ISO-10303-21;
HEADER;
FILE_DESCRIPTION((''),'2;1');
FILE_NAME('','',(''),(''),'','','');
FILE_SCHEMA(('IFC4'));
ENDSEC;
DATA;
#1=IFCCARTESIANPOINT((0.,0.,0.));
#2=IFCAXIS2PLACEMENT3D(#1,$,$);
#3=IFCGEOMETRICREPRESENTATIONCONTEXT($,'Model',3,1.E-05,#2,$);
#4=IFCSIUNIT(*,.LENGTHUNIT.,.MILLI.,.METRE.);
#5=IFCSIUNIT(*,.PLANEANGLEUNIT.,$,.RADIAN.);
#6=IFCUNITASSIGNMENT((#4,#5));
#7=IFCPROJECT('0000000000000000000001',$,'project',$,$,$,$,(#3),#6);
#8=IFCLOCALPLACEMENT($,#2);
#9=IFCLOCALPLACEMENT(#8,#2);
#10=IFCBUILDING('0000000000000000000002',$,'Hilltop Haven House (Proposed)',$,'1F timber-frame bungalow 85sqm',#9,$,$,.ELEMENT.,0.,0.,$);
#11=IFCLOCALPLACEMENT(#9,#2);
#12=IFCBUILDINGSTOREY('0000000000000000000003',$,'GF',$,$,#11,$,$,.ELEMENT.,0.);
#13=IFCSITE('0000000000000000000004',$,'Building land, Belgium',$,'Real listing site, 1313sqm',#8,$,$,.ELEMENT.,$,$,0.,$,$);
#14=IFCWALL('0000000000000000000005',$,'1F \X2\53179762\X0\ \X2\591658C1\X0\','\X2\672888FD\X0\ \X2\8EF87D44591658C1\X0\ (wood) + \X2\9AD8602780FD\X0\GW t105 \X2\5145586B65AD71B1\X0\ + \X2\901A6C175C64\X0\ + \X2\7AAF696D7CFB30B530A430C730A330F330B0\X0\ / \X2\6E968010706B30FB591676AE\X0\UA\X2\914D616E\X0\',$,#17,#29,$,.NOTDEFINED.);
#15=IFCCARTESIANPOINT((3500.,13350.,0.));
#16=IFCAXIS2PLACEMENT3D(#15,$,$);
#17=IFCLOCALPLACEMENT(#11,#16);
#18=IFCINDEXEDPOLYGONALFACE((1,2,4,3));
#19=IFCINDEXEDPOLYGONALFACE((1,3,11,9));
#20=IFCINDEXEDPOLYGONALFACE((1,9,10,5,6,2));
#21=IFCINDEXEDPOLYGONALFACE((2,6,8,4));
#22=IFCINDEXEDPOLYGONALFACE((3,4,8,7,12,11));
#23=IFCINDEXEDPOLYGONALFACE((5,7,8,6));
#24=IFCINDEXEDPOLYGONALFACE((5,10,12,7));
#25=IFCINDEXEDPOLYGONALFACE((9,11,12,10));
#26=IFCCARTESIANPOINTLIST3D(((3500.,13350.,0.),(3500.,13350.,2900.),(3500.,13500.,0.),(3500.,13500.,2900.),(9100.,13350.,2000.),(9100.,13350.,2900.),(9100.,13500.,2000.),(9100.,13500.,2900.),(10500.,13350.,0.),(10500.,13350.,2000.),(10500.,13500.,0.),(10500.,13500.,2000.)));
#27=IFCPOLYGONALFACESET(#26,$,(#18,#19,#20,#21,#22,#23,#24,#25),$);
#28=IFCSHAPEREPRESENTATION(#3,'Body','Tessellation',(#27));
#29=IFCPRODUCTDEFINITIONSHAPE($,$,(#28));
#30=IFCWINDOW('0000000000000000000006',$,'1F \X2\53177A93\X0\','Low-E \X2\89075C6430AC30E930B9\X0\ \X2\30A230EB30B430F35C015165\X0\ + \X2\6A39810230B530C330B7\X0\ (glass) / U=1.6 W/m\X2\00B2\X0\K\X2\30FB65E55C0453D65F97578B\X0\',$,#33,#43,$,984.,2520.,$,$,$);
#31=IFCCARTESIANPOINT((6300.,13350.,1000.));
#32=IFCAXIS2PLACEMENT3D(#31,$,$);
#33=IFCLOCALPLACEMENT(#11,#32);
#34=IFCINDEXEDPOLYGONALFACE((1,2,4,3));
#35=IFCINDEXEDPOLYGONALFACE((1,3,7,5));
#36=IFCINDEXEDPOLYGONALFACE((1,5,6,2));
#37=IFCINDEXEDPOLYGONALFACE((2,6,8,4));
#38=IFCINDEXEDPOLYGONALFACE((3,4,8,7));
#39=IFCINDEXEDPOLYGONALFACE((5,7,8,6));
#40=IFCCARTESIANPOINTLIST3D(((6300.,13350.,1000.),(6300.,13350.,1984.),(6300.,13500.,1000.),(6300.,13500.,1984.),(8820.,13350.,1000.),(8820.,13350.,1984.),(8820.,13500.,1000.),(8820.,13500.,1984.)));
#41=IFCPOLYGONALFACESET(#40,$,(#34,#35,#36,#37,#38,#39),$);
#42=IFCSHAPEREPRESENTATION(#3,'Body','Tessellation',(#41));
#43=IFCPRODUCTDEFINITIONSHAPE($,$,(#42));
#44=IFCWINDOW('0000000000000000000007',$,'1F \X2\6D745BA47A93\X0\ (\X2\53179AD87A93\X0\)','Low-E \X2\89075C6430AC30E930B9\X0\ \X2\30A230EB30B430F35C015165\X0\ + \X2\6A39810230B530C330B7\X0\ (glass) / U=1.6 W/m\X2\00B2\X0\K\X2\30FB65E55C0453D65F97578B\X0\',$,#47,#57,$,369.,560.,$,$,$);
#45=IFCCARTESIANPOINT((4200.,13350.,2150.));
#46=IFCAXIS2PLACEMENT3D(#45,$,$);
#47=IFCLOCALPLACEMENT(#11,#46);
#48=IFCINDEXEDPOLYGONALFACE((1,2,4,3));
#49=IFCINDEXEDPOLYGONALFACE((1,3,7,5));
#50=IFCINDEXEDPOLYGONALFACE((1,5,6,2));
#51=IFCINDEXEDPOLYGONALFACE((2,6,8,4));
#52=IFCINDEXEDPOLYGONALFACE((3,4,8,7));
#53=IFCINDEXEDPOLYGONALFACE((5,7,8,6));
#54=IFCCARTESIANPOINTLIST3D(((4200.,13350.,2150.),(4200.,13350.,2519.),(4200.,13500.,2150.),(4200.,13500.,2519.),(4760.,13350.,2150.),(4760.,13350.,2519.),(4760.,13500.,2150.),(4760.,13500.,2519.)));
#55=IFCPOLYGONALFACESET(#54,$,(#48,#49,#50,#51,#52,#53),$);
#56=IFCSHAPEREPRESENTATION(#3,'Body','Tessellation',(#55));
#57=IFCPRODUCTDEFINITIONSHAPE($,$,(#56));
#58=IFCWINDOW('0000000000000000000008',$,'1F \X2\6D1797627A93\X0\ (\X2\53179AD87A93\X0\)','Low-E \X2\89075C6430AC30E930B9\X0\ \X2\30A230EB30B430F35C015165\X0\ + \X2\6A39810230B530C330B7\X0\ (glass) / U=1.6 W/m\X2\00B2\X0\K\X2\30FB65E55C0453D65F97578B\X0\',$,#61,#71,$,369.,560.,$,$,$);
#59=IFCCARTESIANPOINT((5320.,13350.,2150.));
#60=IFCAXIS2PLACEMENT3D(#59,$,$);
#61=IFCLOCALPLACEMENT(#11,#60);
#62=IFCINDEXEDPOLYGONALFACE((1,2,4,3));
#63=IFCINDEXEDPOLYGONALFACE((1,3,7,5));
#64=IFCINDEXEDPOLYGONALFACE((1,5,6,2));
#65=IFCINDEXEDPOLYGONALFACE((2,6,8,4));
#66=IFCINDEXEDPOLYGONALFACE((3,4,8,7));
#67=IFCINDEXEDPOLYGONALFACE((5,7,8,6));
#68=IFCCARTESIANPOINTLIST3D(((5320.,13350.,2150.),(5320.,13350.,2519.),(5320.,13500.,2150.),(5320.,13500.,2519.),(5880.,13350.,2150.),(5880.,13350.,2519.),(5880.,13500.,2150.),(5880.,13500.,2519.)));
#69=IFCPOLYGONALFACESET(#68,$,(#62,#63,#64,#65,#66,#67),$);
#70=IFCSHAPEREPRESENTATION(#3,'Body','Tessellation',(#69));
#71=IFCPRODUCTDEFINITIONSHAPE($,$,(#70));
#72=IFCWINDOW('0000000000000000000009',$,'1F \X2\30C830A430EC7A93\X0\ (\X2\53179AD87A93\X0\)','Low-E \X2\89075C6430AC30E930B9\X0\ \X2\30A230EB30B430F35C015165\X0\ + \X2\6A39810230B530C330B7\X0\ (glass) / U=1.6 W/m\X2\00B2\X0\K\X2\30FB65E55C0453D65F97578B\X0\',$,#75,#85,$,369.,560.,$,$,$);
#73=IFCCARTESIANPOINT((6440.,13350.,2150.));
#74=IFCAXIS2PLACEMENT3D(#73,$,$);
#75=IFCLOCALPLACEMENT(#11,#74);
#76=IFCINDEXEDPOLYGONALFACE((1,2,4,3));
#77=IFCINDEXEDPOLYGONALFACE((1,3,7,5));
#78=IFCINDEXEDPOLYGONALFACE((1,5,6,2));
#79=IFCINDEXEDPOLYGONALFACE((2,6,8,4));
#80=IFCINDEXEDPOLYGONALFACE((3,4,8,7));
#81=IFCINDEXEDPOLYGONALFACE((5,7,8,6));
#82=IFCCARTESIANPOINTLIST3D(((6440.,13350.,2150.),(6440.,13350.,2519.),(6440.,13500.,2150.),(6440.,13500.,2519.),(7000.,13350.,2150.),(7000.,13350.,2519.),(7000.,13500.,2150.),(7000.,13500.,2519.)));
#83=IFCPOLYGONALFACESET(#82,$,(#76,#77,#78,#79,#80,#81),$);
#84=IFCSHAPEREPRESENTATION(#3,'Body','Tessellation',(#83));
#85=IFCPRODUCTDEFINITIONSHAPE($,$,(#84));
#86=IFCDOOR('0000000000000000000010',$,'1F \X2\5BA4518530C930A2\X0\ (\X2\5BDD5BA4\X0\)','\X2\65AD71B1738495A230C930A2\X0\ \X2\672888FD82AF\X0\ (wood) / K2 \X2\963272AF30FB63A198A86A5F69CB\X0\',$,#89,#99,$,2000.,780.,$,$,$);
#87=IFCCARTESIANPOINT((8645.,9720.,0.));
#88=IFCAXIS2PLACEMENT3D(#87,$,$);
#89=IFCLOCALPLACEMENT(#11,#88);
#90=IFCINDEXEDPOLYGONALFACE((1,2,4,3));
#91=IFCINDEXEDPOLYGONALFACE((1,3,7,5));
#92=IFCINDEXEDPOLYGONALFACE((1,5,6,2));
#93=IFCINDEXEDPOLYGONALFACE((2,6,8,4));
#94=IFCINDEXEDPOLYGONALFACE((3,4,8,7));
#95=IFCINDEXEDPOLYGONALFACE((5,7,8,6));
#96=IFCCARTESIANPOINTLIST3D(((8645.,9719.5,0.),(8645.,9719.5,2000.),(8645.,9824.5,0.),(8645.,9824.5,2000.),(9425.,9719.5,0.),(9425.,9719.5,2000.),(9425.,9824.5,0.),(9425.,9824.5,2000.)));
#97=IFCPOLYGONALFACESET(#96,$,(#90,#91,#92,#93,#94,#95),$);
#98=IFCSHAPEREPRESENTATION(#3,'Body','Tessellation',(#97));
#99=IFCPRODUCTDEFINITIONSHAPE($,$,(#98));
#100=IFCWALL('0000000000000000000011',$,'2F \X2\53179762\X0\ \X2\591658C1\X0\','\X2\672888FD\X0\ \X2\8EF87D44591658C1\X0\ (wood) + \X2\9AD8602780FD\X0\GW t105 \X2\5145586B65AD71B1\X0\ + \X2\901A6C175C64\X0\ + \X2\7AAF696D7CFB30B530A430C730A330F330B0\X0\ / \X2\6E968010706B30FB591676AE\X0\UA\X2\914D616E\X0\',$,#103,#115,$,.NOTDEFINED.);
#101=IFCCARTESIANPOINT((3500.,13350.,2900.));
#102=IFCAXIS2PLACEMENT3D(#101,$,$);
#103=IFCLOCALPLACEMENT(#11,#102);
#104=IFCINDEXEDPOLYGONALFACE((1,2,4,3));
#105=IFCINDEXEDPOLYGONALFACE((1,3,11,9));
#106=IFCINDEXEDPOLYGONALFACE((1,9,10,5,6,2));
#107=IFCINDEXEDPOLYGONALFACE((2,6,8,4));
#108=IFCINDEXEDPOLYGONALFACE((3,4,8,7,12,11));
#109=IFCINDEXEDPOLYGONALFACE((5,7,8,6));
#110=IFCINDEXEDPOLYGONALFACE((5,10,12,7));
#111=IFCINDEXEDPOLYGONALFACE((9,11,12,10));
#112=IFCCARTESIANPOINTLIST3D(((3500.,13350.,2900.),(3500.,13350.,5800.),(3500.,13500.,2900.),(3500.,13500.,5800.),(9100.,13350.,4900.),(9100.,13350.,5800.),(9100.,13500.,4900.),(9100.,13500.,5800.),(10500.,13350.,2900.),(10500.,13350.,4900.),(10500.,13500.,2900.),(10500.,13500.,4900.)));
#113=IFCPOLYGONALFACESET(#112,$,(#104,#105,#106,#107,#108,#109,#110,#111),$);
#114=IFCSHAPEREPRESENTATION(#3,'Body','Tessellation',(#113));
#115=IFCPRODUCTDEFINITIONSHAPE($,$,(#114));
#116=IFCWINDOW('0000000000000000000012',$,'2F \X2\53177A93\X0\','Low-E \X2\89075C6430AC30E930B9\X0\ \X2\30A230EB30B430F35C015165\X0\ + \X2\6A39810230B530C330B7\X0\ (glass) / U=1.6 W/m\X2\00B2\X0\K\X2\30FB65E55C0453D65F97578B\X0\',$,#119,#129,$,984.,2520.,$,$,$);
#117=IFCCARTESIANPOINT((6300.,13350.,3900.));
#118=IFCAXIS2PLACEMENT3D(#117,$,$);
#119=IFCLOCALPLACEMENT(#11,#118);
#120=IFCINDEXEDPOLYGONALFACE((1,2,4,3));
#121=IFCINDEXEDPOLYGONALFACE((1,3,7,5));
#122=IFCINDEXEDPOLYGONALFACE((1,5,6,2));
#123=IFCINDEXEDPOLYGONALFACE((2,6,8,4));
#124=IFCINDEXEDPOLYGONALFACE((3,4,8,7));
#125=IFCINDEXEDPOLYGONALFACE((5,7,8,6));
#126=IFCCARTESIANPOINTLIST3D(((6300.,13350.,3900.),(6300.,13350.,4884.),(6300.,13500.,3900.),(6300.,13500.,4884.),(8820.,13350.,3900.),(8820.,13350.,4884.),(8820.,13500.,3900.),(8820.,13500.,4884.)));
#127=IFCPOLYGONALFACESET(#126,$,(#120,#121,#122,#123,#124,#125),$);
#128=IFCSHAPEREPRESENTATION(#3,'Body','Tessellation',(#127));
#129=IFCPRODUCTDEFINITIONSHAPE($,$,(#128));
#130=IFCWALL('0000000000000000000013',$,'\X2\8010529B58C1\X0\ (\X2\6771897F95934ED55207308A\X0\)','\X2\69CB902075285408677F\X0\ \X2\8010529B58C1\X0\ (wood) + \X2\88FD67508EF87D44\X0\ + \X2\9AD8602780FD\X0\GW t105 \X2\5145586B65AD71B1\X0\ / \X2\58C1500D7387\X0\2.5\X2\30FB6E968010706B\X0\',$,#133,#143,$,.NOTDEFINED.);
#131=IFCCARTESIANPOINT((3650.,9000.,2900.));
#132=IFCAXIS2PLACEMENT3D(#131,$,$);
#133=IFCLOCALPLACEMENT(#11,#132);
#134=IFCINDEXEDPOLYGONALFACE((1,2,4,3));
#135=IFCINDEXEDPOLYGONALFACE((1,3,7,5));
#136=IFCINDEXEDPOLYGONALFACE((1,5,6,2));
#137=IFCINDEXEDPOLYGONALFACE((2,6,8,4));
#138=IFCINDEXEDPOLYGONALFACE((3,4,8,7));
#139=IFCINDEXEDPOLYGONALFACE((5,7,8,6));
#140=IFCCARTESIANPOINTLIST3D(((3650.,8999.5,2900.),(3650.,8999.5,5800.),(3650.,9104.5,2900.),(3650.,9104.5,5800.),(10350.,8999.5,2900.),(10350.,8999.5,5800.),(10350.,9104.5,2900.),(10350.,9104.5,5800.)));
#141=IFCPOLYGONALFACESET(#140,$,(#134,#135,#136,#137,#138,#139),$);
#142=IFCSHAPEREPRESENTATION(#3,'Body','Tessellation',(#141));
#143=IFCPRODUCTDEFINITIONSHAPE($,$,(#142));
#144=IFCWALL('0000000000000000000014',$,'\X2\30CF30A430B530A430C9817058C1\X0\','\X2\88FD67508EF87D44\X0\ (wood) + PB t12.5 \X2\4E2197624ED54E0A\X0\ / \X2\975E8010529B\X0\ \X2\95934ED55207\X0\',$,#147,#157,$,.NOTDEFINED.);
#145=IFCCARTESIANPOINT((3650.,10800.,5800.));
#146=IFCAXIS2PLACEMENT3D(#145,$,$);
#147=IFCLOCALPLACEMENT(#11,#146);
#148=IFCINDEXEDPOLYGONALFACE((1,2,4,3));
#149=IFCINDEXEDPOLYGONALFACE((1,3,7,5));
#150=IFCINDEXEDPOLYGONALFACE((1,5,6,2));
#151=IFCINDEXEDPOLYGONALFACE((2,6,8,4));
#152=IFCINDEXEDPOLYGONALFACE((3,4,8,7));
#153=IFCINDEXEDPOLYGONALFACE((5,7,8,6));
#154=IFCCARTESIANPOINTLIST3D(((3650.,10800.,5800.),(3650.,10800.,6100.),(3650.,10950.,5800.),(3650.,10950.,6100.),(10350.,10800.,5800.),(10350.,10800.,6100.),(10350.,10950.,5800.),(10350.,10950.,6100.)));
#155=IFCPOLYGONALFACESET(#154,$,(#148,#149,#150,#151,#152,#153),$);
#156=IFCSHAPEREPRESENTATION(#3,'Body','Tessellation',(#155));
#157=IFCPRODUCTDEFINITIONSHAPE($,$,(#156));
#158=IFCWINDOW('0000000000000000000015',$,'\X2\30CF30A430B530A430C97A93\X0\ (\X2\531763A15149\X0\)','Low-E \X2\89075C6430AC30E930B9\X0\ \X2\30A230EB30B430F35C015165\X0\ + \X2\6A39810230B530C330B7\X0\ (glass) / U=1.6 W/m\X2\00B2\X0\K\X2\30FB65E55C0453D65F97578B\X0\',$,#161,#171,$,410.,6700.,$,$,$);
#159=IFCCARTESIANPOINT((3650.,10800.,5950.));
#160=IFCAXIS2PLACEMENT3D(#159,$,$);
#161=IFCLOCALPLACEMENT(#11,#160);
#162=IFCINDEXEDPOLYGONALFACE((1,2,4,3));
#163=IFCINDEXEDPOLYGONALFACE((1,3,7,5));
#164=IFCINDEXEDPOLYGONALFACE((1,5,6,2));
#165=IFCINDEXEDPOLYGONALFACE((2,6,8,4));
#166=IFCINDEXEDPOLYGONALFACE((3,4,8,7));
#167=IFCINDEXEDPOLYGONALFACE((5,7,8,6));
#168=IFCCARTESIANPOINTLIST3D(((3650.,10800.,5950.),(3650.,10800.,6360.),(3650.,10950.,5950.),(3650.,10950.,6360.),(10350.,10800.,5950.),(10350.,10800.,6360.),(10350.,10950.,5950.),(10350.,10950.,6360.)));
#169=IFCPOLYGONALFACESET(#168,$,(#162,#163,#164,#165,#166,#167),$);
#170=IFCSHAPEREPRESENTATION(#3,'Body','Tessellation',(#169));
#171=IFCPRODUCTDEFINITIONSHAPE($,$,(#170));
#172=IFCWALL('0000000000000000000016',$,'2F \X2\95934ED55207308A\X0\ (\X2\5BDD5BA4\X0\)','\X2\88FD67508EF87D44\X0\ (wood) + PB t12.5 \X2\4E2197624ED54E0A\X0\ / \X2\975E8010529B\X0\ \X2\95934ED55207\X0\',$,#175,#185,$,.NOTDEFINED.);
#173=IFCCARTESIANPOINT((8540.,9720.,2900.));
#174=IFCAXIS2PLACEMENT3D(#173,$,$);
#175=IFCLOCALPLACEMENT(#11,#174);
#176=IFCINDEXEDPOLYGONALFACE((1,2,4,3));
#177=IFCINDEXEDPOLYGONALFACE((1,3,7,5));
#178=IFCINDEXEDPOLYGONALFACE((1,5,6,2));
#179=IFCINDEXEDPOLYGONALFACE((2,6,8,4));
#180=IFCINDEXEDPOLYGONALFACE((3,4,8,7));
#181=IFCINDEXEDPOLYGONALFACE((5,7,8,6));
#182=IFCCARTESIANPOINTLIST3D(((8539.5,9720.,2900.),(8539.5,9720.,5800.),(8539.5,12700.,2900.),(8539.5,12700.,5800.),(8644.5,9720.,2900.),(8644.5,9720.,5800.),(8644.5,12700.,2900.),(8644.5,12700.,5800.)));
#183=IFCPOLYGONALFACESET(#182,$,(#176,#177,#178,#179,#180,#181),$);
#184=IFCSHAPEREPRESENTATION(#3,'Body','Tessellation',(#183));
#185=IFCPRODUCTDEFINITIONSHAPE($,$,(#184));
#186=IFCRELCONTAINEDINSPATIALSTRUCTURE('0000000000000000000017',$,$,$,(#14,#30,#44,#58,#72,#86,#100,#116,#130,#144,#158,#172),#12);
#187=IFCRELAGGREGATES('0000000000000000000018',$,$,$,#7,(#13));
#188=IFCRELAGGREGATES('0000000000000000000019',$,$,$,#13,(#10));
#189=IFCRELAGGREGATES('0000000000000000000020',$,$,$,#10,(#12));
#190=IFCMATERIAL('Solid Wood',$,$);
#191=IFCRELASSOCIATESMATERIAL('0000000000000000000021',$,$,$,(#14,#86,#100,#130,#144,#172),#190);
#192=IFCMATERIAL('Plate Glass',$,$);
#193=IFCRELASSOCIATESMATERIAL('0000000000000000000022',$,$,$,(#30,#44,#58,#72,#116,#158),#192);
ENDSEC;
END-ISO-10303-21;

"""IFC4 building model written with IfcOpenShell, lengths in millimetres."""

from ifc_helpers import new_model, si_unit, frame, frame_2d, origin, place, context, project, spatial, rectangle, extrude, material, element, fill, save


model = new_model("IFC4")

# Units and contexts
model_context = context("Model", 3, precision=1e-05, world=origin())
ifc_project = project(units=[si_unit("LENGTHUNIT", "METRE", prefix="MILLI"), si_unit("PLANEANGLEUNIT", "RADIAN")], contexts=[model_context])

# Site, building, storey
site_placement = place(None, origin())
site = spatial("IfcSite", under=ifc_project, at=site_placement, Name="Building land, Belgium", ObjectType="Real listing site, 1313sqm", CompositionType="ELEMENT", RefElevation=0.0)
building_placement = place(site_placement, origin())
building = spatial("IfcBuilding", under=site, at=building_placement, Name="Hilltop Haven House (Proposed)", ObjectType="1F timber-frame bungalow 85sqm", CompositionType="ELEMENT", ElevationOfRefHeight=0.0, ElevationOfTerrain=0.0)
storey_placement = place(building_placement, origin())
storey = spatial("IfcBuildingStorey", under=building, at=storey_placement, Name="GF", CompositionType="ELEMENT", Elevation=0.0)

# Wall, openings, windows
ifc_material_1 = material(Name="Solid Wood")
wall_1_placement = place(storey_placement, frame((3500.0, 13350.0, 0.0)))
wall_1 = element("IfcWall", 1, at=wall_1_placement, inside=storey, material=ifc_material_1, Name="1F 北面 外壁", Description="木製 軸組外壁 (wood) + 高性能GW t105 充填断熱 + 通気層 + 窯業系サイディング / 準耐火・外皮UA配慮", PredefinedType="NOTDEFINED", context=model_context, shape_type="SweptSolid", body=[
    extrude(rectangle(XDim=7000.0, YDim=150.0, at=frame_2d((3500.0, 75.0))), frame((3500.0, 13350.0, 0.0)), (0.0, 0.0, 1.0), 2900.0),
])
opening_1_placement = place(storey_placement, frame((6300.0, 13350.0, 1000.0)))
opening_1 = element("IfcOpeningElement", 2, at=opening_1_placement, cuts=wall_1, PredefinedType="NOTDEFINED", context=model_context, shape_type="SweptSolid", body=[
    extrude(rectangle(XDim=2520.0, YDim=150.0, at=frame_2d((1260.0, 75.0))), frame((6300.0, 13350.0, 1000.0)), (0.0, 0.0, 1.0), 984.0),
])
opening_2_placement = place(storey_placement, frame((4200.0, 13350.0, 2150.0)))
opening_2 = element("IfcOpeningElement", 3, at=opening_2_placement, cuts=wall_1, PredefinedType="NOTDEFINED", context=model_context, shape_type="SweptSolid", body=[
    extrude(rectangle(XDim=560.0, YDim=150.0, at=frame_2d((280.0, 75.0))), frame((4200.0, 13350.0, 2150.0)), (0.0, 0.0, 1.0), 369.0),
])
opening_3_placement = place(storey_placement, frame((5320.0, 13350.0, 2150.0)))
opening_3 = element("IfcOpeningElement", 4, at=opening_3_placement, cuts=wall_1, PredefinedType="NOTDEFINED", context=model_context, shape_type="SweptSolid", body=[
    extrude(rectangle(XDim=560.0, YDim=150.0, at=frame_2d((280.0, 75.0))), frame((5320.0, 13350.0, 2150.0)), (0.0, 0.0, 1.0), 369.0),
])
opening_4_placement = place(storey_placement, frame((6440.0, 13350.0, 2150.0)))
opening_4 = element("IfcOpeningElement", 5, at=opening_4_placement, cuts=wall_1, PredefinedType="NOTDEFINED", context=model_context, shape_type="SweptSolid", body=[
    extrude(rectangle(XDim=560.0, YDim=150.0, at=frame_2d((280.0, 75.0))), frame((6440.0, 13350.0, 2150.0)), (0.0, 0.0, 1.0), 369.0),
])
ifc_material_2 = material(Name="Plate Glass")
window_1_placement = place(storey_placement, frame((6300.0, 13350.0, 1000.0)))
window_1 = element("IfcWindow", 6, at=window_1_placement, inside=storey, material=ifc_material_2, Name="1F 北窓", Description="Low-E 複層ガラス アルゴン封入 + 樹脂サッシ (glass) / U=1.6 W/m²K・日射取得型", OverallHeight=984.0, OverallWidth=2520.0, context=model_context, shape_type="SweptSolid", body=[
    extrude(rectangle(XDim=2520.0, YDim=150.0, at=frame_2d((1260.0, 75.0))), frame((6300.0, 13350.0, 1000.0)), (0.0, 0.0, 1.0), 984.0),
])
fill(opening_1, window_1)
window_2_placement = place(storey_placement, frame((4200.0, 13350.0, 2150.0)))
window_2 = element("IfcWindow", 7, at=window_2_placement, inside=storey, material=ifc_material_2, Name="1F 浴室窓 (北高窓)", Description="Low-E 複層ガラス アルゴン封入 + 樹脂サッシ (glass) / U=1.6 W/m²K・日射取得型", OverallHeight=369.0, OverallWidth=560.0, context=model_context, shape_type="SweptSolid", body=[
    extrude(rectangle(XDim=560.0, YDim=150.0, at=frame_2d((280.0, 75.0))), frame((4200.0, 13350.0, 2150.0)), (0.0, 0.0, 1.0), 369.0),
])
fill(opening_2, window_2)
window_3_placement = place(storey_placement, frame((5320.0, 13350.0, 2150.0)))
window_3 = element("IfcWindow", 8, at=window_3_placement, inside=storey, material=ifc_material_2, Name="1F 洗面窓 (北高窓)", Description="Low-E 複層ガラス アルゴン封入 + 樹脂サッシ (glass) / U=1.6 W/m²K・日射取得型", OverallHeight=369.0, OverallWidth=560.0, context=model_context, shape_type="SweptSolid", body=[
    extrude(rectangle(XDim=560.0, YDim=150.0, at=frame_2d((280.0, 75.0))), frame((5320.0, 13350.0, 2150.0)), (0.0, 0.0, 1.0), 369.0),
])
fill(opening_3, window_3)
window_4_placement = place(storey_placement, frame((6440.0, 13350.0, 2150.0)))
window_4 = element("IfcWindow", 9, at=window_4_placement, inside=storey, material=ifc_material_2, Name="1F トイレ窓 (北高窓)", Description="Low-E 複層ガラス アルゴン封入 + 樹脂サッシ (glass) / U=1.6 W/m²K・日射取得型", OverallHeight=369.0, OverallWidth=560.0, context=model_context, shape_type="SweptSolid", body=[
    extrude(rectangle(XDim=560.0, YDim=150.0, at=frame_2d((280.0, 75.0))), frame((6440.0, 13350.0, 2150.0)), (0.0, 0.0, 1.0), 369.0),
])
fill(opening_4, window_4)

# Door
door_1_placement = place(storey_placement, frame((8645.0, 9720.0, 0.0)))
element("IfcDoor", 10, at=door_1_placement, inside=storey, material=ifc_material_1, Name="1F 室内ドア (寝室)", Description="断熱玄関ドア 木製芯 (wood) / K2 防犯・採風機構", OverallHeight=2000.0, OverallWidth=780.0, context=model_context, shape_type="SweptSolid", body=[
    extrude(rectangle(XDim=780.0, YDim=105.0, at=frame_2d((390.0, 52.0))), frame((8645.0, 9720.0, 0.0)), (0.0, 0.0, 1.0), 2000.0),
])

# Wall, opening, window
wall_2_placement = place(storey_placement, frame((3500.0, 13350.0, 2900.0)))
wall_2 = element("IfcWall", 11, at=wall_2_placement, inside=storey, material=ifc_material_1, Name="2F 北面 外壁", Description="木製 軸組外壁 (wood) + 高性能GW t105 充填断熱 + 通気層 + 窯業系サイディング / 準耐火・外皮UA配慮", PredefinedType="NOTDEFINED", context=model_context, shape_type="SweptSolid", body=[
    extrude(rectangle(XDim=7000.0, YDim=150.0, at=frame_2d((3500.0, 75.0))), frame((3500.0, 13350.0, 2900.0)), (0.0, 0.0, 1.0), 2900.0),
])
opening_5_placement = place(storey_placement, frame((6300.0, 13350.0, 3900.0)))
opening_5 = element("IfcOpeningElement", 12, at=opening_5_placement, cuts=wall_2, PredefinedType="NOTDEFINED", context=model_context, shape_type="SweptSolid", body=[
    extrude(rectangle(XDim=2520.0, YDim=150.0, at=frame_2d((1260.0, 75.0))), frame((6300.0, 13350.0, 3900.0)), (0.0, 0.0, 1.0), 984.0),
])
window_5_placement = place(storey_placement, frame((6300.0, 13350.0, 3900.0)))
window_5 = element("IfcWindow", 13, at=window_5_placement, inside=storey, material=ifc_material_2, Name="2F 北窓", Description="Low-E 複層ガラス アルゴン封入 + 樹脂サッシ (glass) / U=1.6 W/m²K・日射取得型", OverallHeight=984.0, OverallWidth=2520.0, context=model_context, shape_type="SweptSolid", body=[
    extrude(rectangle(XDim=2520.0, YDim=150.0, at=frame_2d((1260.0, 75.0))), frame((6300.0, 13350.0, 3900.0)), (0.0, 0.0, 1.0), 984.0),
])
fill(opening_5, window_5)

# Wall
wall_3_placement = place(storey_placement, frame((3650.0, 9000.0, 2900.0)))
element("IfcWall", 14, at=wall_3_placement, inside=storey, material=ifc_material_1, Name="耐力壁 (東西間仕切り)", Description="構造用合板 耐力壁 (wood) + 製材軸組 + 高性能GW t105 充填断熱 / 壁倍率2.5・準耐火", PredefinedType="NOTDEFINED", context=model_context, shape_type="SweptSolid", body=[
    extrude(rectangle(XDim=6700.0, YDim=105.0, at=frame_2d((3350.0, 52.0))), frame((3650.0, 9000.0, 2900.0)), (0.0, 0.0, 1.0), 2900.0),
])

# Wall, opening, window
wall_4_placement = place(storey_placement, frame((3650.0, 10800.0, 5800.0)))
wall_4 = element("IfcWall", 15, at=wall_4_placement, inside=storey, material=ifc_material_1, Name="ハイサイド腰壁", Description="製材軸組 (wood) + PB t12.5 両面仕上 / 非耐力 間仕切", PredefinedType="NOTDEFINED", context=model_context, shape_type="SweptSolid", body=[
    extrude(rectangle(XDim=6700.0, YDim=150.0, at=frame_2d((3350.0, 75.0))), frame((3650.0, 10800.0, 5800.0)), (0.0, 0.0, 1.0), 700.0),
])
opening_6_placement = place(storey_placement, frame((3650.0, 10800.0, 5950.0)))
opening_6 = element("IfcOpeningElement", 16, at=opening_6_placement, cuts=wall_4, PredefinedType="NOTDEFINED", context=model_context, shape_type="SweptSolid", body=[
    extrude(rectangle(XDim=6700.0, YDim=150.0, at=frame_2d((3350.0, 75.0))), frame((3650.0, 10800.0, 5950.0)), (0.0, 0.0, 1.0), 410.0),
])
window_6_placement = place(storey_placement, frame((3650.0, 10800.0, 5950.0)))
window_6 = element("IfcWindow", 17, at=window_6_placement, inside=storey, material=ifc_material_2, Name="ハイサイド窓 (北採光)", Description="Low-E 複層ガラス アルゴン封入 + 樹脂サッシ (glass) / U=1.6 W/m²K・日射取得型", OverallHeight=410.0, OverallWidth=6700.0, context=model_context, shape_type="SweptSolid", body=[
    extrude(rectangle(XDim=6700.0, YDim=150.0, at=frame_2d((3350.0, 75.0))), frame((3650.0, 10800.0, 5950.0)), (0.0, 0.0, 1.0), 410.0),
])
fill(opening_6, window_6)

# Wall
wall_5_placement = place(storey_placement, frame((8540.0, 9720.0, 2900.0)))
element("IfcWall", 18, at=wall_5_placement, inside=storey, material=ifc_material_1, Name="2F 間仕切り (寝室)", Description="製材軸組 (wood) + PB t12.5 両面仕上 / 非耐力 間仕切", PredefinedType="NOTDEFINED", context=model_context, shape_type="SweptSolid", body=[
    extrude(rectangle(XDim=105.0, YDim=2980.0, at=frame_2d((52.0, 1490.0))), frame((8540.0, 9720.0, 2900.0)), (0.0, 0.0, 1.0), 2900.0),
])

save(model, "model.ifc")
